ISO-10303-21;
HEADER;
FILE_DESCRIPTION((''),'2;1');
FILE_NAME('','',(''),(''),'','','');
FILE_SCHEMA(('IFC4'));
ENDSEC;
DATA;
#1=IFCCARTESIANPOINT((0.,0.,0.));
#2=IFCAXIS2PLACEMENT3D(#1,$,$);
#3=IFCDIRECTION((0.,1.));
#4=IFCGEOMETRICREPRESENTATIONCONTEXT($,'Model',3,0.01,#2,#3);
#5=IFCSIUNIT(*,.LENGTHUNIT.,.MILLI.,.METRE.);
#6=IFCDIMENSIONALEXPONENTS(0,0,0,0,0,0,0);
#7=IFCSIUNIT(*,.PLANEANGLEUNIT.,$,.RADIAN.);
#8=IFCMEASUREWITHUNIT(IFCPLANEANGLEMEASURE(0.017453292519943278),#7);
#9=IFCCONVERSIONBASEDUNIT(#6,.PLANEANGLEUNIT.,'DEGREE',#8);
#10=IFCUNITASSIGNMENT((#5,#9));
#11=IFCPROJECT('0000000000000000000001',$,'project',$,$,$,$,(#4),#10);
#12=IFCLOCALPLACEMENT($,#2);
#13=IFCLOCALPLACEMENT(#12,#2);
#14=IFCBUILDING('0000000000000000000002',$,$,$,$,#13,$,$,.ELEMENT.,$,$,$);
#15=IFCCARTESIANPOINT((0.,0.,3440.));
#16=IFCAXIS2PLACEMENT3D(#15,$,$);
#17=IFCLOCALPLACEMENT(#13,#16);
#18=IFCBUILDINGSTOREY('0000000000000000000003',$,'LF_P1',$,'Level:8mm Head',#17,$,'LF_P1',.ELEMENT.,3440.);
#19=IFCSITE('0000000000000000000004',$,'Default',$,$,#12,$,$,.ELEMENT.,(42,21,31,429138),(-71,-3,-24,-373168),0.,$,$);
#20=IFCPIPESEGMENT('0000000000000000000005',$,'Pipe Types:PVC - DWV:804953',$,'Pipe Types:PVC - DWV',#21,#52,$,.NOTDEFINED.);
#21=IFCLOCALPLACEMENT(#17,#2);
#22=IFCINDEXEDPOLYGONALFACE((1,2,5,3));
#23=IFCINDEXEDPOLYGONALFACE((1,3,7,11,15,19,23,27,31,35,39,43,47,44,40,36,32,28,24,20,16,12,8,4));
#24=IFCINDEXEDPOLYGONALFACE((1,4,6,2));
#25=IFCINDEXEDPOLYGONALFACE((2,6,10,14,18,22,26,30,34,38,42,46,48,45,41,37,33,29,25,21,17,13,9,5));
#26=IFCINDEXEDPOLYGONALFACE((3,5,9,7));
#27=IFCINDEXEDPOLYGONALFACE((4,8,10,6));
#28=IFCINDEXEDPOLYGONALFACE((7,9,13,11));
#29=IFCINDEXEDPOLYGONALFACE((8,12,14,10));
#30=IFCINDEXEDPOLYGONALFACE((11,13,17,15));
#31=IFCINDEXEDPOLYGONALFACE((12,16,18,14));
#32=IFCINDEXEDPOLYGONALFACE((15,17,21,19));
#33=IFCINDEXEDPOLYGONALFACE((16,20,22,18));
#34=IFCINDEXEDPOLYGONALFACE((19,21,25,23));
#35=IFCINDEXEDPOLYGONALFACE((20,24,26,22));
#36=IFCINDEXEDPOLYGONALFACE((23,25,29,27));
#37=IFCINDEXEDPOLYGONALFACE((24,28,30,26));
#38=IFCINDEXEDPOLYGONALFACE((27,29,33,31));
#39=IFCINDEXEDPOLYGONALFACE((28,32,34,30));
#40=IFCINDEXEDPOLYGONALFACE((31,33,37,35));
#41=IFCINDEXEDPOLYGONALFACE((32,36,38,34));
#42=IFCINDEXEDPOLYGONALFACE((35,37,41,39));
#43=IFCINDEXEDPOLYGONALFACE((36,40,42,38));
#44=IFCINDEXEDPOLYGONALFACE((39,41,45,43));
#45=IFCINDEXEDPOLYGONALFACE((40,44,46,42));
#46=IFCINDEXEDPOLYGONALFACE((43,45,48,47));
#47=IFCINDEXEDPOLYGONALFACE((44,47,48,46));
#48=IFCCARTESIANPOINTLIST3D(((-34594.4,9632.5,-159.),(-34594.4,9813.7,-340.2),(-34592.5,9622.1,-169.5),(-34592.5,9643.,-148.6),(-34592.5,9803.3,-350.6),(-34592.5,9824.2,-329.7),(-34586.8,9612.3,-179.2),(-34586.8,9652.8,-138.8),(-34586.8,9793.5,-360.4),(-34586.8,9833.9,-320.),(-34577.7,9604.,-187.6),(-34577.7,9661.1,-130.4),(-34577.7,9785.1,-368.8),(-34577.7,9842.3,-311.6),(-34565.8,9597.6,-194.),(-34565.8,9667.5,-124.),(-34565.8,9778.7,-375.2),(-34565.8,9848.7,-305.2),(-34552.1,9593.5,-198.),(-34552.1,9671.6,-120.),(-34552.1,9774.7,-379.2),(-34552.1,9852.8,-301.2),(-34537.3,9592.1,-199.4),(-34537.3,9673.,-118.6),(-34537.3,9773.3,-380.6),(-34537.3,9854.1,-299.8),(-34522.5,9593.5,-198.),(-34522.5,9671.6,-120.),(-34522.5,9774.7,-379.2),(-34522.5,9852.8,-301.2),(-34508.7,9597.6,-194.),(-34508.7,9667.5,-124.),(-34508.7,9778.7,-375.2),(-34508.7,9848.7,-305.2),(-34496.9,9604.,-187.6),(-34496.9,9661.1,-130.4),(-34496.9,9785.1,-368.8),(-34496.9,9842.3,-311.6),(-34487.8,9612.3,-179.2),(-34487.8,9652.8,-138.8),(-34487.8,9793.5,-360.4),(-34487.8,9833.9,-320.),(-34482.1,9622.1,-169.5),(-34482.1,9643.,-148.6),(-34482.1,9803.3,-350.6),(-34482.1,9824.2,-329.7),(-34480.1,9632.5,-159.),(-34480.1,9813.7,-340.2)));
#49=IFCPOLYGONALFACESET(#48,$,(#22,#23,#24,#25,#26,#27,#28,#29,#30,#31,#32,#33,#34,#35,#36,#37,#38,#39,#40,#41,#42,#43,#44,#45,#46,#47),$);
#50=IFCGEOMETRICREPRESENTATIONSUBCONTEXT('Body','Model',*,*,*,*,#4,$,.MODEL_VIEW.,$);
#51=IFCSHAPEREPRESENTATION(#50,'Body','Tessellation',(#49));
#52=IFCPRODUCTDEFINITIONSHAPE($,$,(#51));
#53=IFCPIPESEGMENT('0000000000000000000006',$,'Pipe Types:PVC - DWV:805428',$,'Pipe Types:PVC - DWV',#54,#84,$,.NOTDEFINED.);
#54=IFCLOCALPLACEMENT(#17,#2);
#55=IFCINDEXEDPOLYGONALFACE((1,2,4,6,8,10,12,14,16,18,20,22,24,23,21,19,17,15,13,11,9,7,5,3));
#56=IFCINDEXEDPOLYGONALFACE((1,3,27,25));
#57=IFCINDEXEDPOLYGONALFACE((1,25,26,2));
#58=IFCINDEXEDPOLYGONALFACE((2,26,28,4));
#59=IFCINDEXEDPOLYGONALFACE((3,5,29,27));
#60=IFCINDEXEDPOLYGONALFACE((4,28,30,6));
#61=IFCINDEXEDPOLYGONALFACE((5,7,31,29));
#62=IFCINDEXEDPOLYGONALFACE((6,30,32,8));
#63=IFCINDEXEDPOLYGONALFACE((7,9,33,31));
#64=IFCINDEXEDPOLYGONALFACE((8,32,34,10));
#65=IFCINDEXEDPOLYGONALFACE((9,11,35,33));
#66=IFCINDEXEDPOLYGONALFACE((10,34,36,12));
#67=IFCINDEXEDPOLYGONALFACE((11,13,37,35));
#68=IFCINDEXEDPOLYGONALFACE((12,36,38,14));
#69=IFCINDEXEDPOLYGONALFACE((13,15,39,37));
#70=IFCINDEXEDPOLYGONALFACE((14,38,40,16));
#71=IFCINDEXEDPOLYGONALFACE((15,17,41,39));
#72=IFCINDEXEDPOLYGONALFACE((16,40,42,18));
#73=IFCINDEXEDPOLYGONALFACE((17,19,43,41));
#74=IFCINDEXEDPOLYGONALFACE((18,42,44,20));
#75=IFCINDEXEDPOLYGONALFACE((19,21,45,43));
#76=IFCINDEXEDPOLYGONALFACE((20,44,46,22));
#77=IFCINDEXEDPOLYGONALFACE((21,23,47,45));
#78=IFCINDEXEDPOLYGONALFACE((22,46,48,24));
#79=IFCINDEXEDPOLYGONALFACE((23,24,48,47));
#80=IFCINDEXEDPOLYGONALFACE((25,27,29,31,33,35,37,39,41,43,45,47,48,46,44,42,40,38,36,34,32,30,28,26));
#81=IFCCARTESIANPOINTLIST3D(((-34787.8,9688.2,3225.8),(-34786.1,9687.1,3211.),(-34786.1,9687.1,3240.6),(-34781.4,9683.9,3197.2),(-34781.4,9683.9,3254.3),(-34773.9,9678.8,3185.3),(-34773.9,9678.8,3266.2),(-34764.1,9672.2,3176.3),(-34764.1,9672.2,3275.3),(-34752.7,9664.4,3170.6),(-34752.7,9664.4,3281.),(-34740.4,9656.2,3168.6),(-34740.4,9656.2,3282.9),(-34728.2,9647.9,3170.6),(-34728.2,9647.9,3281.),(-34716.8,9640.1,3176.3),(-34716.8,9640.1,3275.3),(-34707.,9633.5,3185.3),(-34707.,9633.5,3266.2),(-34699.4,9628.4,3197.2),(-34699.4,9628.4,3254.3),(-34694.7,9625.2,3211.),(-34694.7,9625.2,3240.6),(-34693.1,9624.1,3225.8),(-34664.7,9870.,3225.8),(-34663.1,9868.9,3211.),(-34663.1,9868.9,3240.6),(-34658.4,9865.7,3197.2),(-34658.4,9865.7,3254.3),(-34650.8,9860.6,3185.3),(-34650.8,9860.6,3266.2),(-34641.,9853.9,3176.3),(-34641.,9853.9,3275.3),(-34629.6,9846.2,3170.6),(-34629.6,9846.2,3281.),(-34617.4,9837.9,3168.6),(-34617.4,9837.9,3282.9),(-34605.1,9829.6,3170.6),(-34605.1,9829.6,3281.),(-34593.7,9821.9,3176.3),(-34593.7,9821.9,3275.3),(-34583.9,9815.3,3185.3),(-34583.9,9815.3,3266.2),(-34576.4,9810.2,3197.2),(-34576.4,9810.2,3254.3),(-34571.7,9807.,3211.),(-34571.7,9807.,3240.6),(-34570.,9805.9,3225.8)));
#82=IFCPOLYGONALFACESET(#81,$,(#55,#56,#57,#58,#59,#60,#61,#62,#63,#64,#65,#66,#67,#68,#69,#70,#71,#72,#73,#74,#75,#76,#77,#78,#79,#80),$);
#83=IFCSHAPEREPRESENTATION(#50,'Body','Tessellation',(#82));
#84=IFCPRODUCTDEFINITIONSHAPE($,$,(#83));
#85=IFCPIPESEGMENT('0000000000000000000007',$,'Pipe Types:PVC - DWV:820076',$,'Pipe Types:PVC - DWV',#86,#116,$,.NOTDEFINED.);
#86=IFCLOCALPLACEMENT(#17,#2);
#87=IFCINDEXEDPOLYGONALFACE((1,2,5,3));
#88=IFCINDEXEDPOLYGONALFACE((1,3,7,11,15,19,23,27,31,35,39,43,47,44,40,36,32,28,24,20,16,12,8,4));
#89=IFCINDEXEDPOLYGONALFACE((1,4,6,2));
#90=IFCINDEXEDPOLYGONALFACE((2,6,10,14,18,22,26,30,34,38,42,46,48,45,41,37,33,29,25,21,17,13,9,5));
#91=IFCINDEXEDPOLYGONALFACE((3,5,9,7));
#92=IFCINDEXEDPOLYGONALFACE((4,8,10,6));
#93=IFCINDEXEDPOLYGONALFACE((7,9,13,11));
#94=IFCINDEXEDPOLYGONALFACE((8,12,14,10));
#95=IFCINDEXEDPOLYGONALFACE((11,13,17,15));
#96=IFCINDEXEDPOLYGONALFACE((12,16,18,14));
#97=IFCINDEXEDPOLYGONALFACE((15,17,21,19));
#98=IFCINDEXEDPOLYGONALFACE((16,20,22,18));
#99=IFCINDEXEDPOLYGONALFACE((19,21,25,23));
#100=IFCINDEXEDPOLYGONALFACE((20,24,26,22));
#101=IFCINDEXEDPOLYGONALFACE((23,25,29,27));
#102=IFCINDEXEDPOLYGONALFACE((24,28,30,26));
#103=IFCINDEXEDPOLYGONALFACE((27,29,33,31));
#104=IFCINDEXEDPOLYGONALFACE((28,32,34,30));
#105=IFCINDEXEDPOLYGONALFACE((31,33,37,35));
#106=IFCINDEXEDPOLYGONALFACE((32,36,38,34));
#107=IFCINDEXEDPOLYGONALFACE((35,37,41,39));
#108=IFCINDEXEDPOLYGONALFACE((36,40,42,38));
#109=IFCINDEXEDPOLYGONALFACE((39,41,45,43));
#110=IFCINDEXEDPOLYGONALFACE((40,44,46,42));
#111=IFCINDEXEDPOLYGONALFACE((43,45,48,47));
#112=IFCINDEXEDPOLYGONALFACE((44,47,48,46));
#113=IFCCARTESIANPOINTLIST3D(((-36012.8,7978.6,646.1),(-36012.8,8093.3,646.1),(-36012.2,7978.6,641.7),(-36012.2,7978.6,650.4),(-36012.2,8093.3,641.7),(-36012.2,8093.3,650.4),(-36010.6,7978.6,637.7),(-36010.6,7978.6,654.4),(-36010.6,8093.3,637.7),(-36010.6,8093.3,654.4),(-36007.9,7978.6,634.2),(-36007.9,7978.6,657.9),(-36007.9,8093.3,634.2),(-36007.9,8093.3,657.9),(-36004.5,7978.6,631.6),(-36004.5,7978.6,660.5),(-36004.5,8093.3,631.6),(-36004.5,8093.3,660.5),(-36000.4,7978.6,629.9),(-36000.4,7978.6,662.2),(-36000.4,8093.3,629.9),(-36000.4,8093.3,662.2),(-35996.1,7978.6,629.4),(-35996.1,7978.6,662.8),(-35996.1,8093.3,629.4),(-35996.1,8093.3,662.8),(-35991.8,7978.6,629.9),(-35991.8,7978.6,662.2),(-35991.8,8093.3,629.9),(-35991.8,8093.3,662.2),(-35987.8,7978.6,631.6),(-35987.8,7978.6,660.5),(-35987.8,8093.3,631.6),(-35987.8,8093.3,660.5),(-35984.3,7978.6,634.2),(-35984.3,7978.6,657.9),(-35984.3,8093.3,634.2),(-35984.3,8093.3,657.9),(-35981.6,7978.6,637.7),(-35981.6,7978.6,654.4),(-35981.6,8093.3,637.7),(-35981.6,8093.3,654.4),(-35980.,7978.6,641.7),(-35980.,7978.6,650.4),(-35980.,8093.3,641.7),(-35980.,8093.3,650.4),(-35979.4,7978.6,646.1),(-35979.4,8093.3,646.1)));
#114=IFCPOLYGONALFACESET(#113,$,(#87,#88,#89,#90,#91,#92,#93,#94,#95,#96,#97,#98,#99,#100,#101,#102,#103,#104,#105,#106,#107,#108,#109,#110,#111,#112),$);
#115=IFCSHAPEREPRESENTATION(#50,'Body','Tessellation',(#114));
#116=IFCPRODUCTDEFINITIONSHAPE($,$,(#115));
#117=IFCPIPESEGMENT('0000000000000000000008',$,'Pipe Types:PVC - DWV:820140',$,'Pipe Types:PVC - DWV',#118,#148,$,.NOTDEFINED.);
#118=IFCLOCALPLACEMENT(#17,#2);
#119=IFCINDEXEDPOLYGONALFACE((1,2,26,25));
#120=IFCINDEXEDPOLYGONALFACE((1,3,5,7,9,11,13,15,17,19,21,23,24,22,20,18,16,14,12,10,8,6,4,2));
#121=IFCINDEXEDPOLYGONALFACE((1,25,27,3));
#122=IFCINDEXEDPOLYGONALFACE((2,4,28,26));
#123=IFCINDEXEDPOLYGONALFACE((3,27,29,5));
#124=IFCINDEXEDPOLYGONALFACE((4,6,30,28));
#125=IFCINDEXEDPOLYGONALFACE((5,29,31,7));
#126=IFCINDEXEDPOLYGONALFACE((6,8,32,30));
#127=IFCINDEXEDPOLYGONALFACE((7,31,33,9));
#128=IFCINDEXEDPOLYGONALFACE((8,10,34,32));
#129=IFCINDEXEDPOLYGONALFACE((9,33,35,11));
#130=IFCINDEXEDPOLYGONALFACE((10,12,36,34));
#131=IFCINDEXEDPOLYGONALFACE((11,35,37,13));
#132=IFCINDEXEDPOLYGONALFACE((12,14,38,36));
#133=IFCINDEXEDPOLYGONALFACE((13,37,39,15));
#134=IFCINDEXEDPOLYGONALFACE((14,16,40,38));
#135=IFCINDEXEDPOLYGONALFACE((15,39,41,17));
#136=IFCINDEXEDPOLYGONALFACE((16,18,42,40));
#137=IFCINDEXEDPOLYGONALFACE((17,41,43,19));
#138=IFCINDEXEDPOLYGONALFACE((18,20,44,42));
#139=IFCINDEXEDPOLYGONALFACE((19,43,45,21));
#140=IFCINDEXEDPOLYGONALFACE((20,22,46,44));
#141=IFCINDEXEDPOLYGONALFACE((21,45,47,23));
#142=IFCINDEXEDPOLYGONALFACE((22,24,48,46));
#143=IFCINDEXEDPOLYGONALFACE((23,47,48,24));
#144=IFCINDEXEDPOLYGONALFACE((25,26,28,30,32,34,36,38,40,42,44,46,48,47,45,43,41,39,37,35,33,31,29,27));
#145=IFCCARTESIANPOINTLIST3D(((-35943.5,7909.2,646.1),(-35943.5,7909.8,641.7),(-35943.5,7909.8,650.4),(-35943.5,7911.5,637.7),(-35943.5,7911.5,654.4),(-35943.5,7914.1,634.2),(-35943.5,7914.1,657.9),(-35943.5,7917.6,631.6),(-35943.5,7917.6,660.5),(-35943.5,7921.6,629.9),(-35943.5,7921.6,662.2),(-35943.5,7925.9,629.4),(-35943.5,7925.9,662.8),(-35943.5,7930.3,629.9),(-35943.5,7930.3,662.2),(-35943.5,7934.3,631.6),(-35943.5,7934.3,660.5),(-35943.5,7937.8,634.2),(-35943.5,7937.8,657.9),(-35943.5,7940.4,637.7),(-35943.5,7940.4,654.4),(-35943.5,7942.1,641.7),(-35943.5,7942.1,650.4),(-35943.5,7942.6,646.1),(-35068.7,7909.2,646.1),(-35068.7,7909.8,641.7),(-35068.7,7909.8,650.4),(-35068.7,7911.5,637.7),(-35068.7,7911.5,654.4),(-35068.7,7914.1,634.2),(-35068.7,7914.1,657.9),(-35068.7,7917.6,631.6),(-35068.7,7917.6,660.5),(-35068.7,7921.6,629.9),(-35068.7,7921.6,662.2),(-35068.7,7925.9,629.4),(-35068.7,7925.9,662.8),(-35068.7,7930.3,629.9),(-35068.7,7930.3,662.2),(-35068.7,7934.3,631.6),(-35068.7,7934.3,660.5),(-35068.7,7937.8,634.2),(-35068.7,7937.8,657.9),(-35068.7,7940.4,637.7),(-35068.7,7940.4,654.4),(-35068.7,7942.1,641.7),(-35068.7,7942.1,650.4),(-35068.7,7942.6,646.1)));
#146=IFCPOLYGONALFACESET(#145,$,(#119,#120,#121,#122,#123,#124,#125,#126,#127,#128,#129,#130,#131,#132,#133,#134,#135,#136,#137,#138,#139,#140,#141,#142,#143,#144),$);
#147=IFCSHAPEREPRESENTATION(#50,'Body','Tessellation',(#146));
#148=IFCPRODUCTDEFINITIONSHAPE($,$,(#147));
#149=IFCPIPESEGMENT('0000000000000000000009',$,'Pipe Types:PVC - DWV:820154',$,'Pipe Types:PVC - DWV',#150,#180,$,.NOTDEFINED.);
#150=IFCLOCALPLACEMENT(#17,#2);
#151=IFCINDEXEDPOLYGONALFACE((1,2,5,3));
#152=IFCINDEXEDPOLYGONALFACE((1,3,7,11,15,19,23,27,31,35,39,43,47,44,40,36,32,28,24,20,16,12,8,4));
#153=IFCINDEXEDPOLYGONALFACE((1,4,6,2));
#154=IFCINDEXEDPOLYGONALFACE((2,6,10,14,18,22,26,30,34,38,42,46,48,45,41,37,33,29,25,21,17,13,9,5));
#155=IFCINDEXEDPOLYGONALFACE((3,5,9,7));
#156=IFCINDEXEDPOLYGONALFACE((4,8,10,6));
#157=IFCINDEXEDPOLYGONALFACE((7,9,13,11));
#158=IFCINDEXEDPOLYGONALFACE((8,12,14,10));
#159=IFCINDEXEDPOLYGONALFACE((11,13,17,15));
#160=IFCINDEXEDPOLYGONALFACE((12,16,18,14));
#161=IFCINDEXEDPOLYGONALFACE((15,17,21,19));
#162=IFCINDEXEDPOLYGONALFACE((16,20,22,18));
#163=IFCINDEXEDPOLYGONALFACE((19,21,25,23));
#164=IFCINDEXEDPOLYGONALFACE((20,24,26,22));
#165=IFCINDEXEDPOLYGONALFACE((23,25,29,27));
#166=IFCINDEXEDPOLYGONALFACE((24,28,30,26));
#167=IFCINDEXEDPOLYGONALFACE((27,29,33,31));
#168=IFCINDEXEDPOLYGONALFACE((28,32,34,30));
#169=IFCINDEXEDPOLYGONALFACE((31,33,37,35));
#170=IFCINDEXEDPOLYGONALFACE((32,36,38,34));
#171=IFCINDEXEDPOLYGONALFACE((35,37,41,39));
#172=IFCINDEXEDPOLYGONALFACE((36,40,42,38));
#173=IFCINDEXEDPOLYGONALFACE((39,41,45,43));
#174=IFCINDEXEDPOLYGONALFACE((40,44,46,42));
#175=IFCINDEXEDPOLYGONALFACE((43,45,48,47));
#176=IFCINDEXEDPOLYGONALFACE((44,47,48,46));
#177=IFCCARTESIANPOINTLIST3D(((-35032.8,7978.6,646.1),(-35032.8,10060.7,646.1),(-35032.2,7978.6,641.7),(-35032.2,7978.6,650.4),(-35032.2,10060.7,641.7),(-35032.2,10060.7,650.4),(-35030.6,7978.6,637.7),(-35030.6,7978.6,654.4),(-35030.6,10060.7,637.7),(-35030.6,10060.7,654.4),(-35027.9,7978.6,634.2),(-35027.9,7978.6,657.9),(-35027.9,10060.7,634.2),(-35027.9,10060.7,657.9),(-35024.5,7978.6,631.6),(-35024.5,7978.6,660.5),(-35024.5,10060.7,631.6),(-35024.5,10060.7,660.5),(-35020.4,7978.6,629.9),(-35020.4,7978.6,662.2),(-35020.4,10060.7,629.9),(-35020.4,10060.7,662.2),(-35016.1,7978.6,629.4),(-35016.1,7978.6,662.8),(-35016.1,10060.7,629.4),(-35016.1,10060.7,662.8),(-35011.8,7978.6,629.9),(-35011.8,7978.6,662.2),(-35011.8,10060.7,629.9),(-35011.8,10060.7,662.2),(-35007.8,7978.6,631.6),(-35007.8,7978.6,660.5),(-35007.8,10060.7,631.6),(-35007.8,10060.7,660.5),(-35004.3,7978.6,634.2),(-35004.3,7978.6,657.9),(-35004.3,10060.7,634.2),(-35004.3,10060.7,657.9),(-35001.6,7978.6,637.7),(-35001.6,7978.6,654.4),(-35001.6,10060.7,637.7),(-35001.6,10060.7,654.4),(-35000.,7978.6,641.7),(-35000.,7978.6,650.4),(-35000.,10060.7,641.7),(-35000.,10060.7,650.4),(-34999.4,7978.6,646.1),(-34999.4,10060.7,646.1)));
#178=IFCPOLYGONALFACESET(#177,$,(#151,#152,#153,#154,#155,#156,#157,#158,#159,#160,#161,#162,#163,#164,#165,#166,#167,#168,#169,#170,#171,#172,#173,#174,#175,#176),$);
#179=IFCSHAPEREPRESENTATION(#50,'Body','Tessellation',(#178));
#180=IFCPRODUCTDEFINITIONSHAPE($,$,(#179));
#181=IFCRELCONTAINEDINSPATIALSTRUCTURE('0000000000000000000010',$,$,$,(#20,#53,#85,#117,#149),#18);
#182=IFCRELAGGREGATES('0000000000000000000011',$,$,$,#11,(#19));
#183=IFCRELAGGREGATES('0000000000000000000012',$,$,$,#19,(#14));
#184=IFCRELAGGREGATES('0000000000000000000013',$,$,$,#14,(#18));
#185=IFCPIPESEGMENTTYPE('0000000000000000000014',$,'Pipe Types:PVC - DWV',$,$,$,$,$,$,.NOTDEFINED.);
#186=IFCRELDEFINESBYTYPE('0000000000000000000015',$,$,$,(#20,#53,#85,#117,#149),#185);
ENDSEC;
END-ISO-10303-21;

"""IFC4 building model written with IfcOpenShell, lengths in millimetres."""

from ifc_helpers import new_model, entity, si_unit, converted_unit, direction, frame, origin, place, context, subcontext, project, spatial, arc, indexed_curve, outline, extrude, type_object, element, save


model = new_model("IFC4")

# Units and contexts
model_context = context("Model", 3, precision=0.01, world=origin(), true_north=direction((0.0, 1.0)))
body_context = subcontext(model_context, "Body", "Model", "MODEL_VIEW")
ifc_project = project(units=[si_unit("LENGTHUNIT", "METRE", prefix="MILLI"), converted_unit("PLANEANGLEUNIT", "DEGREE", entity("IfcPlaneAngleMeasure", 0.017453292519943278), si_unit("PLANEANGLEUNIT", "RADIAN"), dimensions=[0, 0, 0, 0, 0, 0, 0])], contexts=[model_context])

# Site, building, storey
site_placement = place(None, origin())
site = spatial("IfcSite", under=ifc_project, at=site_placement, Name="Default", CompositionType="ELEMENT", RefLatitude=(42, 21, 31, 429138), RefLongitude=(-71, -3, -24, -373168), RefElevation=0.0)
building_placement = place(site_placement, origin())
building = spatial("IfcBuilding", under=site, at=building_placement, CompositionType="ELEMENT")
storey_placement = place(building_placement, frame((0.0, 0.0, 3440.0)))
storey = spatial("IfcBuildingStorey", under=building, at=storey_placement, Name="LF_P1", ObjectType="Level:8mm Head", LongName="LF_P1", CompositionType="ELEMENT", Elevation=3440.0)

# Pipe segments
pipe_segment_type_1 = type_object("IfcPipeSegmentType", Name="Pipe Types:PVC - DWV", PredefinedType="NOTDEFINED")
pipe_segment_1_placement = place(storey_placement, origin())
element("IfcPipeSegment", 1, at=pipe_segment_1_placement, inside=storey, type_object=pipe_segment_type_1, Name="Pipe Types:PVC - DWV:804953", ObjectType="Pipe Types:PVC - DWV", PredefinedType="NOTDEFINED", context=body_context, shape_type="SweptSolid", body=[
    extrude(outline(indexed_curve([(57.2, 0.0), (40.4, 40.4), (0.0, 57.1), (-40.4, 40.4), (-57.2, 0.0), (-40.4, -40.4), (0.0, -57.1), (40.4, -40.4)], segments=[arc(1, 2, 3), arc(3, 4, 5), arc(5, 6, 7), arc(7, 8, 1)], self_intersect=False)), frame((-34537.3, 9813.7, -340.2), z_axis=(0.0, -0.707107, 0.707107), x_axis=(-1.0, 0.0, 0.0)), (0.0, 0.0, 1.0), 256.2),
])
pipe_segment_2_placement = place(storey_placement, origin())
element("IfcPipeSegment", 2, at=pipe_segment_2_placement, inside=storey, type_object=pipe_segment_type_1, Name="Pipe Types:PVC - DWV:805428", ObjectType="Pipe Types:PVC - DWV", PredefinedType="NOTDEFINED", context=body_context, shape_type="SweptSolid", body=[
    extrude(outline(indexed_curve([(57.2, 0.0), (40.4, 40.4), (0.0, 57.2), (-40.4, 40.4), (-57.2, 0.0), (-40.4, -40.4), (0.0, -57.2), (40.4, -40.4)], segments=[arc(1, 2, 3), arc(3, 4, 5), arc(5, 6, 7), arc(7, 8, 1)], self_intersect=False)), frame((-34740.4, 9656.2, 3225.8), z_axis=(0.560621, 0.828073, 0.0), x_axis=(-0.828073, 0.560621, 0.0)), (0.0, 0.0, 1.0), 219.5),
])
pipe_segment_3_placement = place(storey_placement, origin())
element("IfcPipeSegment", 3, at=pipe_segment_3_placement, inside=storey, type_object=pipe_segment_type_1, Name="Pipe Types:PVC - DWV:820076", ObjectType="Pipe Types:PVC - DWV", PredefinedType="NOTDEFINED", context=body_context, shape_type="SweptSolid", body=[
    extrude(outline(indexed_curve([(16.7, 0.0), (11.8, 11.8), (0.0, 16.7), (-11.8, 11.8), (-16.7, 0.0), (-11.8, -11.8), (0.0, -16.7), (11.8, -11.8)], segments=[arc(1, 2, 3), arc(3, 4, 5), arc(5, 6, 7), arc(7, 8, 1)], self_intersect=False)), frame((-35996.1, 7978.6, 646.1), z_axis=(0.0, 1.0, 0.0), x_axis=(-1.0, 0.0, 0.0)), (0.0, 0.0, 1.0), 114.8),
])
pipe_segment_4_placement = place(storey_placement, origin())
element("IfcPipeSegment", 4, at=pipe_segment_4_placement, inside=storey, type_object=pipe_segment_type_1, Name="Pipe Types:PVC - DWV:820140", ObjectType="Pipe Types:PVC - DWV", PredefinedType="NOTDEFINED", context=body_context, shape_type="SweptSolid", body=[
    extrude(outline(indexed_curve([(16.7, 0.0), (11.8, 11.8), (0.0, 16.7), (-11.8, 11.8), (-16.7, 0.0), (-11.8, -11.8), (0.0, -16.7), (11.8, -11.8)], segments=[arc(1, 2, 3), arc(3, 4, 5), arc(5, 6, 7), arc(7, 8, 1)], self_intersect=False)), frame((-35943.5, 7925.9, 646.1), z_axis=(1.0, 0.0, 0.0), x_axis=(0.0, -1.0, 0.0)), (0.0, 0.0, 1.0), 874.8),
])
pipe_segment_5_placement = place(storey_placement, origin())
element("IfcPipeSegment", 5, at=pipe_segment_5_placement, inside=storey, type_object=pipe_segment_type_1, Name="Pipe Types:PVC - DWV:820154", ObjectType="Pipe Types:PVC - DWV", PredefinedType="NOTDEFINED", context=body_context, shape_type="SweptSolid", body=[
    extrude(outline(indexed_curve([(16.7, 0.0), (11.8, 11.8), (0.0, 16.7), (-11.8, 11.8), (-16.7, 0.0), (-11.8, -11.8), (0.0, -16.7), (11.8, -11.8)], segments=[arc(1, 2, 3), arc(3, 4, 5), arc(5, 6, 7), arc(7, 8, 1)], self_intersect=False)), frame((-35016.1, 7978.6, 646.1), z_axis=(0.0, 1.0, 0.0), x_axis=(1.0, 0.0, 0.0)), (0.0, 0.0, 1.0), 2082.2),
])

save(model, "model.ifc")
